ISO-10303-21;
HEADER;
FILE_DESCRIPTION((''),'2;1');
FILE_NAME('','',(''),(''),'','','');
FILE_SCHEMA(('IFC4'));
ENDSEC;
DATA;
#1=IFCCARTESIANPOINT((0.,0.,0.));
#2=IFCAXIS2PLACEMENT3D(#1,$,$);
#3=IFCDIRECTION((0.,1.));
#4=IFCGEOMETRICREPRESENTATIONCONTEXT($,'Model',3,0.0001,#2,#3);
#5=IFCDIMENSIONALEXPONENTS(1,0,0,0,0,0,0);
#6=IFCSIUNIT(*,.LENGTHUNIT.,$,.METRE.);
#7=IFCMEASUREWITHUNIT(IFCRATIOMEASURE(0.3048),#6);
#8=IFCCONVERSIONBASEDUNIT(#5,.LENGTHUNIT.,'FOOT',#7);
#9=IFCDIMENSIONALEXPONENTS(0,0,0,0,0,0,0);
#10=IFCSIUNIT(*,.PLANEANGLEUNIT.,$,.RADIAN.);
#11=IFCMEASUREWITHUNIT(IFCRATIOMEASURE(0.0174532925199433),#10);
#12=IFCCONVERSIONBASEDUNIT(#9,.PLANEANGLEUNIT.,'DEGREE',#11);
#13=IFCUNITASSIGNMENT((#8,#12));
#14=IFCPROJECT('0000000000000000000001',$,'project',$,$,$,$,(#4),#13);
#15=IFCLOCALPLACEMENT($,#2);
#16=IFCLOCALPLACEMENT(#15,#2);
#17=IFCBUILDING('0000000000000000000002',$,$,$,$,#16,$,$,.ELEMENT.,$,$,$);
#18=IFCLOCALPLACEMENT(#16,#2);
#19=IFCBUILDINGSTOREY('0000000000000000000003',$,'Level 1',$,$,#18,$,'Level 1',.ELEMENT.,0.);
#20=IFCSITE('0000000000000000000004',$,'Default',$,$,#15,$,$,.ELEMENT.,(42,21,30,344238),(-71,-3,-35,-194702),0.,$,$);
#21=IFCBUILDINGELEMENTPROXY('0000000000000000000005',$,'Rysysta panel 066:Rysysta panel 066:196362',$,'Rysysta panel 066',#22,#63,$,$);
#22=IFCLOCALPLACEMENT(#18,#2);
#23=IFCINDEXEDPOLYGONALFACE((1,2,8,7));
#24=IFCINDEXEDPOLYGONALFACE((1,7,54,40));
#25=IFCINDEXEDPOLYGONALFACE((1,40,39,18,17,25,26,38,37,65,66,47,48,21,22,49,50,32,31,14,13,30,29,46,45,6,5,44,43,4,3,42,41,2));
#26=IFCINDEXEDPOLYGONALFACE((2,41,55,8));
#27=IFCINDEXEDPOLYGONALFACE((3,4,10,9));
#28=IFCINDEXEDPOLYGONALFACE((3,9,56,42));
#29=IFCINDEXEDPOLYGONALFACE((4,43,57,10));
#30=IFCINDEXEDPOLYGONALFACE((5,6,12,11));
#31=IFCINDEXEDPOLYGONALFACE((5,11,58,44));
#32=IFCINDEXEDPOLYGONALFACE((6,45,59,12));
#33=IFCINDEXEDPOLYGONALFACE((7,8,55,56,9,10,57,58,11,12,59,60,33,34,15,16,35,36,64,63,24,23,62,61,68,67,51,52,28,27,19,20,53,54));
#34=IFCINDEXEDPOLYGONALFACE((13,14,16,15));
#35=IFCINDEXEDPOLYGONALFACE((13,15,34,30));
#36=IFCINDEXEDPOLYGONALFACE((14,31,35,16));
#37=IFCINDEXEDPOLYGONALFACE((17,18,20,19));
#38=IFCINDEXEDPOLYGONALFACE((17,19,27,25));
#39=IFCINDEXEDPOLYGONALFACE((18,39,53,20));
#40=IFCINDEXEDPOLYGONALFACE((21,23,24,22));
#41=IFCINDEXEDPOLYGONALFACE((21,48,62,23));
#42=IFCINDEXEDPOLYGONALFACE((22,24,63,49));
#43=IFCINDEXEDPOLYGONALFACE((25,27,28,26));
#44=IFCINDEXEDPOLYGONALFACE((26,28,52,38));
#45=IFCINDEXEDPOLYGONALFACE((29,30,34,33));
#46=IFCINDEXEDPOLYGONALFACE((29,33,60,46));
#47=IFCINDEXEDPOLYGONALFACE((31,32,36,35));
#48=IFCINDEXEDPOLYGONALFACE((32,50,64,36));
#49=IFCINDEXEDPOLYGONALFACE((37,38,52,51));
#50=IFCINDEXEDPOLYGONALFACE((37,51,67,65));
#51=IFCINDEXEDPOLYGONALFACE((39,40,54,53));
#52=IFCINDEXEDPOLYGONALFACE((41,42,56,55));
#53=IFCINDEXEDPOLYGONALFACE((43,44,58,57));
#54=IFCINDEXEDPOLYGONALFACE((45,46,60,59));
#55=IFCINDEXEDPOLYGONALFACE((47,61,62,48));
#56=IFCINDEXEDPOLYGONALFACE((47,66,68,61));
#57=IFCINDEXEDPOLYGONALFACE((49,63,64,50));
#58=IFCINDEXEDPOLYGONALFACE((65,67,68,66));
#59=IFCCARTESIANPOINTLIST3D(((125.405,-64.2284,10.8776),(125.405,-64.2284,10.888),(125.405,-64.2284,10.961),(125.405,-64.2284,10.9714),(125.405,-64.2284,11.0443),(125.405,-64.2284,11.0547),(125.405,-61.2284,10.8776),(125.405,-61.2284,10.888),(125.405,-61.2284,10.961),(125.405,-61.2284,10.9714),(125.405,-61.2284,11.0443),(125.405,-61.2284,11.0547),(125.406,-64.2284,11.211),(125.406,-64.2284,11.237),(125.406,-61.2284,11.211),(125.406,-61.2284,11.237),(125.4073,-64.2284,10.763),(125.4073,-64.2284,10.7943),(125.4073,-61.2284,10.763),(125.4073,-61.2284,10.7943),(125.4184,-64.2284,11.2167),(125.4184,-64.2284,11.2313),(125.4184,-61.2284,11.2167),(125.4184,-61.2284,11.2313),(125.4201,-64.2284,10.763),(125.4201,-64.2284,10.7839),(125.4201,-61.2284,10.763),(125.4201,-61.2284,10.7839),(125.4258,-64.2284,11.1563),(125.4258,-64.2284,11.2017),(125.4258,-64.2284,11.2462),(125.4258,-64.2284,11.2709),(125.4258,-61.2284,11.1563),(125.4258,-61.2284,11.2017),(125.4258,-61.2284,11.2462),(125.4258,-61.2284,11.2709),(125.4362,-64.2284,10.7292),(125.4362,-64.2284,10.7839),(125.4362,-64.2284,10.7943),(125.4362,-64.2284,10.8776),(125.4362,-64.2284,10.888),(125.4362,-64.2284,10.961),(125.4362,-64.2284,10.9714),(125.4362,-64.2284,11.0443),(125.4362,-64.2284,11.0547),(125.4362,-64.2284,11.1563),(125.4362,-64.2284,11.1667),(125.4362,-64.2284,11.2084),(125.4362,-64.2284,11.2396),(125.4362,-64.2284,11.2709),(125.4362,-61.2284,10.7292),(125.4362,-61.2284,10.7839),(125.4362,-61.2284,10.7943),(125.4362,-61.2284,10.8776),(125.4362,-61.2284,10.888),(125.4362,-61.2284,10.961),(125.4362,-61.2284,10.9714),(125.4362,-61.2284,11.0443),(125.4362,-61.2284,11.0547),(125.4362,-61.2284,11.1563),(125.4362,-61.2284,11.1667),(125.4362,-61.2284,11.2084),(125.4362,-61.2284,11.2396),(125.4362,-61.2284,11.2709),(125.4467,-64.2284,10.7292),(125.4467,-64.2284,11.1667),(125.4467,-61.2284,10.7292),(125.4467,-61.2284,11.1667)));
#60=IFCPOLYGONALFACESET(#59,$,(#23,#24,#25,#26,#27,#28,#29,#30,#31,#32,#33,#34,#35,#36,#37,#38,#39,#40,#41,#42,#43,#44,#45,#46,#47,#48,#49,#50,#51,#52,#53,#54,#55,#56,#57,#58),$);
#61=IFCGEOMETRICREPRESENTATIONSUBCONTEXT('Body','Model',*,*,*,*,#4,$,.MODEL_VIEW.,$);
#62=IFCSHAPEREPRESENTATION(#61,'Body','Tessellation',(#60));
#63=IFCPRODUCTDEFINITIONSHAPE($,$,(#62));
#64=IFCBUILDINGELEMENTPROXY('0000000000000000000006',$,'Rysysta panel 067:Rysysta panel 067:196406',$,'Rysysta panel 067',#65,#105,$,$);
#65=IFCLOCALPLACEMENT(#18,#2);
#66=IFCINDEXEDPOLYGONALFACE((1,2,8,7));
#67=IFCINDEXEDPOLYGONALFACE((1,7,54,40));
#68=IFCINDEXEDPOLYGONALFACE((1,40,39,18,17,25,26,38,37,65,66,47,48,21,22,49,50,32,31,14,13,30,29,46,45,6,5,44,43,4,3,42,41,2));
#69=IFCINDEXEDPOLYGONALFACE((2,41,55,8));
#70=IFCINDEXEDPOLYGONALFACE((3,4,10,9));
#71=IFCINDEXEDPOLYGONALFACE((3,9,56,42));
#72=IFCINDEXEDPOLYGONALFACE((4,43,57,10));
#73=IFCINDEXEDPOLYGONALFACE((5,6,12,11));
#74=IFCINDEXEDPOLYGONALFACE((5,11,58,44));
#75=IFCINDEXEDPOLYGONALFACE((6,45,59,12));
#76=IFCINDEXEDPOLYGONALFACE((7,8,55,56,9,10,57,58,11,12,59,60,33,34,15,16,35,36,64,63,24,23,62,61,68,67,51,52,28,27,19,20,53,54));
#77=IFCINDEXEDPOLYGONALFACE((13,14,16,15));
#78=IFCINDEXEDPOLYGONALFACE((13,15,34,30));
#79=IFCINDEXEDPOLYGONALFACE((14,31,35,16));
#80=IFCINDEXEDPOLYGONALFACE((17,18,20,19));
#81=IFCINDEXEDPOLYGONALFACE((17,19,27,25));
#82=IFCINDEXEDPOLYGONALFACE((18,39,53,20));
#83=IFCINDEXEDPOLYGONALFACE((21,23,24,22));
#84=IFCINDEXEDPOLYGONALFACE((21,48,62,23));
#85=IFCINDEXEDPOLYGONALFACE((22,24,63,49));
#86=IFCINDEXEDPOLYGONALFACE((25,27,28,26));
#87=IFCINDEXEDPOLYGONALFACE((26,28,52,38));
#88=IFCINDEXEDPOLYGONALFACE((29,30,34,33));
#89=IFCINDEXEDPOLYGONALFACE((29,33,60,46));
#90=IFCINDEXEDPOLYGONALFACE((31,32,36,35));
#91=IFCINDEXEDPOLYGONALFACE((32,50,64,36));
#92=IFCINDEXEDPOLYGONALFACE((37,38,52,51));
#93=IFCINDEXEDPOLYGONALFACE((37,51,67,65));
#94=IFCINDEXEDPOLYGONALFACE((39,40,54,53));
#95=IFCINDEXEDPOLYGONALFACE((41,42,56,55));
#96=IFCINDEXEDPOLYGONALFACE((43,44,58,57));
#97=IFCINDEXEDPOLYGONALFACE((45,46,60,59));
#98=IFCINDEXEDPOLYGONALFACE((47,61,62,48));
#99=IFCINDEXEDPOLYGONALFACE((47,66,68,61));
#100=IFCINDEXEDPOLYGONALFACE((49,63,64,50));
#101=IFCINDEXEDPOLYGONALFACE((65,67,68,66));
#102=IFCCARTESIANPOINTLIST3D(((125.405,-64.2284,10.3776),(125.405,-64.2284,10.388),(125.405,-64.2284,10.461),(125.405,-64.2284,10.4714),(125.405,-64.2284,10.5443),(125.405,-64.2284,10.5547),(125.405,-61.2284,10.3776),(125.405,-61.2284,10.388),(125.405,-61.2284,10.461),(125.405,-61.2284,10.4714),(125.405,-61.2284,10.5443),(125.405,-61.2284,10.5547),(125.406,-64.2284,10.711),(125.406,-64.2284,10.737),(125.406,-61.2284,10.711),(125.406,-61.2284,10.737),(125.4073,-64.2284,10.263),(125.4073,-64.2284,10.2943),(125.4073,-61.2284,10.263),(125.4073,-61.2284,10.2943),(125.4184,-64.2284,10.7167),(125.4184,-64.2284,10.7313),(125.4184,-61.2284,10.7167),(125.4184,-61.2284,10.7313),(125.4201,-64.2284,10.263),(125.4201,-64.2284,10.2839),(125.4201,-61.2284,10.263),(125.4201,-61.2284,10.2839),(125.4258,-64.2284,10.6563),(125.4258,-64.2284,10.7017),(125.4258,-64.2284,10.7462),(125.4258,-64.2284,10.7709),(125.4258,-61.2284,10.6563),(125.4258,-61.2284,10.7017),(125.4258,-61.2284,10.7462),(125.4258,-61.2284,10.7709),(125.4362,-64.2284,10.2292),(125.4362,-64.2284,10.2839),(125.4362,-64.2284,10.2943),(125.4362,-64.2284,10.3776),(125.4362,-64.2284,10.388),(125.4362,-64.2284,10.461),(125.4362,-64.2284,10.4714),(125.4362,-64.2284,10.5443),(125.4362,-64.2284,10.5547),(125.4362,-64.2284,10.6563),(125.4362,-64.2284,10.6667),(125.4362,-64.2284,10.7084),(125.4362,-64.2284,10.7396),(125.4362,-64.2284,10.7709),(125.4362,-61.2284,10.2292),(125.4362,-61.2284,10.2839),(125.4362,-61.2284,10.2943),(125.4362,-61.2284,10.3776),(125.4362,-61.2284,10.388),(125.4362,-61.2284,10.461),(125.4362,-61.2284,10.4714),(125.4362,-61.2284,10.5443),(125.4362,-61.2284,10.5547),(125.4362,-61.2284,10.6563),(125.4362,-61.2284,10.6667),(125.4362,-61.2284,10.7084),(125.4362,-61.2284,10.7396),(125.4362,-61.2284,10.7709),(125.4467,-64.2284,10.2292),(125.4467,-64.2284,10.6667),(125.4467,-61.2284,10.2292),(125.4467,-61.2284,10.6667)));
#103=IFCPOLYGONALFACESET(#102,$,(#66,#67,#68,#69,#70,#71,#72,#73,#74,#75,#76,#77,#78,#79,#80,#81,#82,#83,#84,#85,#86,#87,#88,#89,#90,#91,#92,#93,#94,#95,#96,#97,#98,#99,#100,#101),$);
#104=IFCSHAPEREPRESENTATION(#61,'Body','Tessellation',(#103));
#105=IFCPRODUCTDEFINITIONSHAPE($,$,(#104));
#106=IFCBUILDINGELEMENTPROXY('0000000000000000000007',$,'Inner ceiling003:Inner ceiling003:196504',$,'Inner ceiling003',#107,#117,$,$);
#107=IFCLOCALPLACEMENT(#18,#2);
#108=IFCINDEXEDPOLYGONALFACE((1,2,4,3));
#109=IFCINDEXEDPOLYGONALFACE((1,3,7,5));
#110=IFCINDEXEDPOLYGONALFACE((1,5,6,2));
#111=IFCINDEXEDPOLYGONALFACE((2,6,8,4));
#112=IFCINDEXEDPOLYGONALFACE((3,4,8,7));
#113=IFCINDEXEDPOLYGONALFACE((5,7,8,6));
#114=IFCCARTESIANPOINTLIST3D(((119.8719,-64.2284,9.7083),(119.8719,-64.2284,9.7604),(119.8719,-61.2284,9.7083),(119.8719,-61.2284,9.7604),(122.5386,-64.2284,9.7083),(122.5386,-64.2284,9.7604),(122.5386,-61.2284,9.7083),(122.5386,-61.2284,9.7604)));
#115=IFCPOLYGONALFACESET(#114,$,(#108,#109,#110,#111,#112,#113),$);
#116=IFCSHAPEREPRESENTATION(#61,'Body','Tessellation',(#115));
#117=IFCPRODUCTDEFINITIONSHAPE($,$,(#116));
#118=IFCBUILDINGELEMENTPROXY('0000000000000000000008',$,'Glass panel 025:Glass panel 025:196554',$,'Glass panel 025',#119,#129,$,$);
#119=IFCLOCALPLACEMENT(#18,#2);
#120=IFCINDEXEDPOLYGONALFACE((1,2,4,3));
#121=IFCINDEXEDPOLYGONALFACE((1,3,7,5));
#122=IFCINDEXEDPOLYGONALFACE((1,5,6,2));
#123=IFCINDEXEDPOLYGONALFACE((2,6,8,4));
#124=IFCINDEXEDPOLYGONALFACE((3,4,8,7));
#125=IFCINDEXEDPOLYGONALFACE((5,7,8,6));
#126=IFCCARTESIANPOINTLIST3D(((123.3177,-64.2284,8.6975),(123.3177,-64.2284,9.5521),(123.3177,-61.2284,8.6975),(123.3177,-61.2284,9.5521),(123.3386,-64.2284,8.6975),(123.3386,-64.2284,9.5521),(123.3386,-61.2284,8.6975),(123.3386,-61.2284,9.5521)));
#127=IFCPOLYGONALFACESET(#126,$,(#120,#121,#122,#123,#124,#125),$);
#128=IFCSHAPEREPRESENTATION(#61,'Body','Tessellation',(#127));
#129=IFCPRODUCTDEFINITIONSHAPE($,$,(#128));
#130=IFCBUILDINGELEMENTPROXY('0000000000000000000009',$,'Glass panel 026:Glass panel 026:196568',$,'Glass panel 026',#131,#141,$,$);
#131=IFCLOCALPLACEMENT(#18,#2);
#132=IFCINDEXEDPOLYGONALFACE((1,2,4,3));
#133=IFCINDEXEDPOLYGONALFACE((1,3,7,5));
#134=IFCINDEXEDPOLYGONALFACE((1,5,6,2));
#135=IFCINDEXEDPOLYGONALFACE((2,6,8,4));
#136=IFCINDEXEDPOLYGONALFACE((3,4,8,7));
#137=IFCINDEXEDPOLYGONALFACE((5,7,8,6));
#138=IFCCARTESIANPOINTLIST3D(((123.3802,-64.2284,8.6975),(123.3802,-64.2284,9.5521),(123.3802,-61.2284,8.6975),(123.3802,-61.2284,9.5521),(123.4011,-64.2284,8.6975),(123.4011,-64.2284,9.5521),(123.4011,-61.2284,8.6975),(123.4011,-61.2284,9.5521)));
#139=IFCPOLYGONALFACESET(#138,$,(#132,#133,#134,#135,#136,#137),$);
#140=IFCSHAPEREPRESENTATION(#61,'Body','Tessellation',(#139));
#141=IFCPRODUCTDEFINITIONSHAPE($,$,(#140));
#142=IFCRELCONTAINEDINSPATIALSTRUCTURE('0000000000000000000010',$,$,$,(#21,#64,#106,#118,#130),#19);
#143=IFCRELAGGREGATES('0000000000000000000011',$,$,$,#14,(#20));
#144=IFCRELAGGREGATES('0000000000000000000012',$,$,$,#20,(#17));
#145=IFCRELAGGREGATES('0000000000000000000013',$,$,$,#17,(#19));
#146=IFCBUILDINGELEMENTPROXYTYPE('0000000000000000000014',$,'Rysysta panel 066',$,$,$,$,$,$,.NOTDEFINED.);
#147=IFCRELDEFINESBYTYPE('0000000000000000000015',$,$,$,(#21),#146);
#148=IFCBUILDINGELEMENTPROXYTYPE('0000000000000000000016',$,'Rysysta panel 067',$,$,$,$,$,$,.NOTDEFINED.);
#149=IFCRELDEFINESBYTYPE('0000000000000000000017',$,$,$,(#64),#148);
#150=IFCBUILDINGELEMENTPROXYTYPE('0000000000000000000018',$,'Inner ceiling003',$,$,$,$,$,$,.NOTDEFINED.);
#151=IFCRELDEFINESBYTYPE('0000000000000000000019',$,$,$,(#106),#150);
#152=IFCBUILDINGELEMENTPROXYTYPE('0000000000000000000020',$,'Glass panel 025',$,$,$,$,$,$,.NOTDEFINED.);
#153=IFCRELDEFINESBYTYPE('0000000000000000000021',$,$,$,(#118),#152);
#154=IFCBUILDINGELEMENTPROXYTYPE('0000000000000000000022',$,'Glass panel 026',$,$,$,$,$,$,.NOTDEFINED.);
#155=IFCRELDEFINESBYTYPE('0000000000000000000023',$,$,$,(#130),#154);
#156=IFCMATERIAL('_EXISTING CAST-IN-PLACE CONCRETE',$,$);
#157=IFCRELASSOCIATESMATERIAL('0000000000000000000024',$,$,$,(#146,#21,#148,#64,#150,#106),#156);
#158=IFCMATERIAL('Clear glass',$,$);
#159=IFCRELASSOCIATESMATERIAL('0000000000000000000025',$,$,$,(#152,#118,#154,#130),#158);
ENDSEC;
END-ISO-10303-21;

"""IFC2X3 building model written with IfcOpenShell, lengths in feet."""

from ifc_helpers import new_model, entity, si_unit, converted_unit, direction, frame, frame_2d, origin, origin_2d_with_axis, place, context, subcontext, project, spatial, polyline, rectangle, outline, extrude, source, transform, mapped, material, type_object, type_shapes, element, save


model = new_model("IFC2X3")

# Units and contexts
model_context = context("Model", 3, precision=0.0001, world=origin(), true_north=direction((0.0, 1.0)))
body_context = subcontext(model_context, "Body", "Model", "MODEL_VIEW")
ifc_project = project(units=[converted_unit("LENGTHUNIT", "FOOT", entity("IfcRatioMeasure", 0.3048), si_unit("LENGTHUNIT", "METRE"), dimensions=[1, 0, 0, 0, 0, 0, 0]), converted_unit("PLANEANGLEUNIT", "DEGREE", entity("IfcRatioMeasure", 0.0174532925199433), si_unit("PLANEANGLEUNIT", "RADIAN"), dimensions=[0, 0, 0, 0, 0, 0, 0])], contexts=[model_context])

# Site, building, storey
site_placement = place(None, origin())
site = spatial("IfcSite", under=ifc_project, at=site_placement, Name="Default", CompositionType="ELEMENT", RefLatitude=(42, 21, 30, 344238), RefLongitude=(-71, -3, -35, -194702), RefElevation=0.0)
building_placement = place(site_placement, origin())
building = spatial("IfcBuilding", under=site, at=building_placement, CompositionType="ELEMENT")
storey_placement = place(building_placement, origin())
storey = spatial("IfcBuildingStorey", under=building, at=storey_placement, Name="Level 1", LongName="Level 1", CompositionType="ELEMENT", Elevation=0.0)

# Building element proxies
ifc_material_1 = material(Name="_EXISTING CAST-IN-PLACE CONCRETE")
building_element_proxy_type_1 = type_object("IfcBuildingElementProxyType", Name="Rysysta panel 066", PredefinedType="NOTDEFINED", material=ifc_material_1)
shared_shape_1 = source(origin(), body_context, "Body", "SweptSolid", [
    extrude(outline(polyline([(-0.1457, -0.022), (0.2918, -0.022), (0.2918, -0.0116), (0.2371, -0.0116), (0.2371, 0.0045), (0.258, 0.0045), (0.258, 0.0173), (0.2267, 0.0173), (0.2267, -0.0116), (0.1434, -0.0116), (0.1434, 0.0196), (0.133, 0.0196), (0.133, -0.0116), (0.06, -0.0116), (0.06, 0.0196), (0.0496, 0.0196), (0.0496, -0.0116), (-0.0233, -0.0116), (-0.0233, 0.0196), (-0.0337, 0.0196), (-0.0337, -0.0116), (-0.1353, -0.0116), (-0.1353, -0.0012), (-0.1807, -0.0012), (-0.1899, 0.0186), (-0.216, 0.0186), (-0.2252, -0.0012), (-0.2498, -0.0012), (-0.2498, -0.0116), (-0.2186, -0.0116), (-0.2103, 0.0062), (-0.1956, 0.0062), (-0.1873, -0.0116), (-0.1457, -0.0116), (-0.1457, -0.022)])), frame((125.4246, -64.2284, 11.021), z_axis=(0.0, 1.0, 0.0), x_axis=(0.0, 0.0, -1.0)), (0.0, 0.0, 1.0), 3.0),
])
type_shapes(building_element_proxy_type_1, [shared_shape_1])
proxy_1_placement = place(storey_placement, origin())
element("IfcBuildingElementProxy", 1, at=proxy_1_placement, inside=storey, type_object=building_element_proxy_type_1, material=ifc_material_1, Name="Rysysta panel 066:Rysysta panel 066:196362", ObjectType="Rysysta panel 066", context=body_context, shape_type="MappedRepresentation", body=[
    mapped(shared_shape_1, transform((0.0, 0.0, 0.0), scale=1.0)),
])
building_element_proxy_type_2 = type_object("IfcBuildingElementProxyType", Name="Rysysta panel 067", PredefinedType="NOTDEFINED", material=ifc_material_1)
shared_shape_2 = source(origin(), body_context, "Body", "SweptSolid", [
    extrude(outline(polyline([(-0.1457, -0.022), (0.2918, -0.022), (0.2918, -0.0116), (0.2371, -0.0116), (0.2371, 0.0045), (0.258, 0.0045), (0.258, 0.0173), (0.2267, 0.0173), (0.2267, -0.0116), (0.1434, -0.0116), (0.1434, 0.0196), (0.133, 0.0196), (0.133, -0.0116), (0.06, -0.0116), (0.06, 0.0196), (0.0496, 0.0196), (0.0496, -0.0116), (-0.0233, -0.0116), (-0.0233, 0.0196), (-0.0337, 0.0196), (-0.0337, -0.0116), (-0.1353, -0.0116), (-0.1353, -0.0012), (-0.1807, -0.0012), (-0.1899, 0.0186), (-0.216, 0.0186), (-0.2252, -0.0012), (-0.2498, -0.0012), (-0.2498, -0.0116), (-0.2186, -0.0116), (-0.2103, 0.0062), (-0.1956, 0.0062), (-0.1873, -0.0116), (-0.1457, -0.0116), (-0.1457, -0.022)])), frame((125.4246, -64.2284, 10.521), z_axis=(0.0, 1.0, 0.0), x_axis=(0.0, 0.0, -1.0)), (0.0, 0.0, 1.0), 3.0),
])
type_shapes(building_element_proxy_type_2, [shared_shape_2])
proxy_2_placement = place(storey_placement, origin())
element("IfcBuildingElementProxy", 2, at=proxy_2_placement, inside=storey, type_object=building_element_proxy_type_2, material=ifc_material_1, Name="Rysysta panel 067:Rysysta panel 067:196406", ObjectType="Rysysta panel 067", context=body_context, shape_type="MappedRepresentation", body=[
    mapped(shared_shape_2, transform((0.0, 0.0, 0.0), scale=1.0)),
])
building_element_proxy_type_3 = type_object("IfcBuildingElementProxyType", Name="Inner ceiling003", PredefinedType="NOTDEFINED", material=ifc_material_1)
shared_shape_3 = source(origin(), body_context, "Body", "SweptSolid", [
    extrude(rectangle(XDim=3.0, YDim=2.6667, at=frame_2d((0.0, 0.0), x_axis=(1.0, 0.0))), frame((121.2053, -62.7284, 9.7083), z_axis=(0.0, 0.0, 1.0), x_axis=(0.0, 1.0, 0.0)), (0.0, 0.0, 1.0), 0.0521),
])
type_shapes(building_element_proxy_type_3, [shared_shape_3])
proxy_3_placement = place(storey_placement, origin())
element("IfcBuildingElementProxy", 3, at=proxy_3_placement, inside=storey, type_object=building_element_proxy_type_3, material=ifc_material_1, Name="Inner ceiling003:Inner ceiling003:196504", ObjectType="Inner ceiling003", context=body_context, shape_type="MappedRepresentation", body=[
    mapped(shared_shape_3, transform((0.0, 0.0, 0.0), scale=1.0)),
])
ifc_material_2 = material(Name="Clear glass")
building_element_proxy_type_4 = type_object("IfcBuildingElementProxyType", Name="Glass panel 025", PredefinedType="NOTDEFINED", material=ifc_material_2)
shared_shape_4 = source(origin(), body_context, "Body", "SweptSolid", [
    extrude(rectangle(XDim=3.0, YDim=0.0208, at=frame_2d((0.0, 0.0), x_axis=(1.0, 0.0))), frame((123.3282, -62.7284, 8.6975), z_axis=(0.0, 0.0, 1.0), x_axis=(0.0, 1.0, 0.0)), (0.0, 0.0, 1.0), 0.8546),
])
type_shapes(building_element_proxy_type_4, [shared_shape_4])
proxy_4_placement = place(storey_placement, origin())
element("IfcBuildingElementProxy", 4, at=proxy_4_placement, inside=storey, type_object=building_element_proxy_type_4, material=ifc_material_2, Name="Glass panel 025:Glass panel 025:196554", ObjectType="Glass panel 025", context=body_context, shape_type="MappedRepresentation", body=[
    mapped(shared_shape_4, transform((0.0, 0.0, 0.0), scale=1.0)),
])
building_element_proxy_type_5 = type_object("IfcBuildingElementProxyType", Name="Glass panel 026", PredefinedType="NOTDEFINED", material=ifc_material_2)
shared_shape_5 = source(origin(), body_context, "Body", "SweptSolid", [
    extrude(rectangle(XDim=3.0, YDim=0.0208, at=origin_2d_with_axis()), frame((123.3907, -62.7284, 8.6975), z_axis=(0.0, 0.0, 1.0), x_axis=(0.0, 1.0, 0.0)), (0.0, 0.0, 1.0), 0.8546),
])
type_shapes(building_element_proxy_type_5, [shared_shape_5])
proxy_5_placement = place(storey_placement, origin())
element("IfcBuildingElementProxy", 5, at=proxy_5_placement, inside=storey, type_object=building_element_proxy_type_5, material=ifc_material_2, Name="Glass panel 026:Glass panel 026:196568", ObjectType="Glass panel 026", context=body_context, shape_type="MappedRepresentation", body=[
    mapped(shared_shape_5, transform((0.0, 0.0, 0.0), scale=1.0)),
])

save(model, "model.ifc")
